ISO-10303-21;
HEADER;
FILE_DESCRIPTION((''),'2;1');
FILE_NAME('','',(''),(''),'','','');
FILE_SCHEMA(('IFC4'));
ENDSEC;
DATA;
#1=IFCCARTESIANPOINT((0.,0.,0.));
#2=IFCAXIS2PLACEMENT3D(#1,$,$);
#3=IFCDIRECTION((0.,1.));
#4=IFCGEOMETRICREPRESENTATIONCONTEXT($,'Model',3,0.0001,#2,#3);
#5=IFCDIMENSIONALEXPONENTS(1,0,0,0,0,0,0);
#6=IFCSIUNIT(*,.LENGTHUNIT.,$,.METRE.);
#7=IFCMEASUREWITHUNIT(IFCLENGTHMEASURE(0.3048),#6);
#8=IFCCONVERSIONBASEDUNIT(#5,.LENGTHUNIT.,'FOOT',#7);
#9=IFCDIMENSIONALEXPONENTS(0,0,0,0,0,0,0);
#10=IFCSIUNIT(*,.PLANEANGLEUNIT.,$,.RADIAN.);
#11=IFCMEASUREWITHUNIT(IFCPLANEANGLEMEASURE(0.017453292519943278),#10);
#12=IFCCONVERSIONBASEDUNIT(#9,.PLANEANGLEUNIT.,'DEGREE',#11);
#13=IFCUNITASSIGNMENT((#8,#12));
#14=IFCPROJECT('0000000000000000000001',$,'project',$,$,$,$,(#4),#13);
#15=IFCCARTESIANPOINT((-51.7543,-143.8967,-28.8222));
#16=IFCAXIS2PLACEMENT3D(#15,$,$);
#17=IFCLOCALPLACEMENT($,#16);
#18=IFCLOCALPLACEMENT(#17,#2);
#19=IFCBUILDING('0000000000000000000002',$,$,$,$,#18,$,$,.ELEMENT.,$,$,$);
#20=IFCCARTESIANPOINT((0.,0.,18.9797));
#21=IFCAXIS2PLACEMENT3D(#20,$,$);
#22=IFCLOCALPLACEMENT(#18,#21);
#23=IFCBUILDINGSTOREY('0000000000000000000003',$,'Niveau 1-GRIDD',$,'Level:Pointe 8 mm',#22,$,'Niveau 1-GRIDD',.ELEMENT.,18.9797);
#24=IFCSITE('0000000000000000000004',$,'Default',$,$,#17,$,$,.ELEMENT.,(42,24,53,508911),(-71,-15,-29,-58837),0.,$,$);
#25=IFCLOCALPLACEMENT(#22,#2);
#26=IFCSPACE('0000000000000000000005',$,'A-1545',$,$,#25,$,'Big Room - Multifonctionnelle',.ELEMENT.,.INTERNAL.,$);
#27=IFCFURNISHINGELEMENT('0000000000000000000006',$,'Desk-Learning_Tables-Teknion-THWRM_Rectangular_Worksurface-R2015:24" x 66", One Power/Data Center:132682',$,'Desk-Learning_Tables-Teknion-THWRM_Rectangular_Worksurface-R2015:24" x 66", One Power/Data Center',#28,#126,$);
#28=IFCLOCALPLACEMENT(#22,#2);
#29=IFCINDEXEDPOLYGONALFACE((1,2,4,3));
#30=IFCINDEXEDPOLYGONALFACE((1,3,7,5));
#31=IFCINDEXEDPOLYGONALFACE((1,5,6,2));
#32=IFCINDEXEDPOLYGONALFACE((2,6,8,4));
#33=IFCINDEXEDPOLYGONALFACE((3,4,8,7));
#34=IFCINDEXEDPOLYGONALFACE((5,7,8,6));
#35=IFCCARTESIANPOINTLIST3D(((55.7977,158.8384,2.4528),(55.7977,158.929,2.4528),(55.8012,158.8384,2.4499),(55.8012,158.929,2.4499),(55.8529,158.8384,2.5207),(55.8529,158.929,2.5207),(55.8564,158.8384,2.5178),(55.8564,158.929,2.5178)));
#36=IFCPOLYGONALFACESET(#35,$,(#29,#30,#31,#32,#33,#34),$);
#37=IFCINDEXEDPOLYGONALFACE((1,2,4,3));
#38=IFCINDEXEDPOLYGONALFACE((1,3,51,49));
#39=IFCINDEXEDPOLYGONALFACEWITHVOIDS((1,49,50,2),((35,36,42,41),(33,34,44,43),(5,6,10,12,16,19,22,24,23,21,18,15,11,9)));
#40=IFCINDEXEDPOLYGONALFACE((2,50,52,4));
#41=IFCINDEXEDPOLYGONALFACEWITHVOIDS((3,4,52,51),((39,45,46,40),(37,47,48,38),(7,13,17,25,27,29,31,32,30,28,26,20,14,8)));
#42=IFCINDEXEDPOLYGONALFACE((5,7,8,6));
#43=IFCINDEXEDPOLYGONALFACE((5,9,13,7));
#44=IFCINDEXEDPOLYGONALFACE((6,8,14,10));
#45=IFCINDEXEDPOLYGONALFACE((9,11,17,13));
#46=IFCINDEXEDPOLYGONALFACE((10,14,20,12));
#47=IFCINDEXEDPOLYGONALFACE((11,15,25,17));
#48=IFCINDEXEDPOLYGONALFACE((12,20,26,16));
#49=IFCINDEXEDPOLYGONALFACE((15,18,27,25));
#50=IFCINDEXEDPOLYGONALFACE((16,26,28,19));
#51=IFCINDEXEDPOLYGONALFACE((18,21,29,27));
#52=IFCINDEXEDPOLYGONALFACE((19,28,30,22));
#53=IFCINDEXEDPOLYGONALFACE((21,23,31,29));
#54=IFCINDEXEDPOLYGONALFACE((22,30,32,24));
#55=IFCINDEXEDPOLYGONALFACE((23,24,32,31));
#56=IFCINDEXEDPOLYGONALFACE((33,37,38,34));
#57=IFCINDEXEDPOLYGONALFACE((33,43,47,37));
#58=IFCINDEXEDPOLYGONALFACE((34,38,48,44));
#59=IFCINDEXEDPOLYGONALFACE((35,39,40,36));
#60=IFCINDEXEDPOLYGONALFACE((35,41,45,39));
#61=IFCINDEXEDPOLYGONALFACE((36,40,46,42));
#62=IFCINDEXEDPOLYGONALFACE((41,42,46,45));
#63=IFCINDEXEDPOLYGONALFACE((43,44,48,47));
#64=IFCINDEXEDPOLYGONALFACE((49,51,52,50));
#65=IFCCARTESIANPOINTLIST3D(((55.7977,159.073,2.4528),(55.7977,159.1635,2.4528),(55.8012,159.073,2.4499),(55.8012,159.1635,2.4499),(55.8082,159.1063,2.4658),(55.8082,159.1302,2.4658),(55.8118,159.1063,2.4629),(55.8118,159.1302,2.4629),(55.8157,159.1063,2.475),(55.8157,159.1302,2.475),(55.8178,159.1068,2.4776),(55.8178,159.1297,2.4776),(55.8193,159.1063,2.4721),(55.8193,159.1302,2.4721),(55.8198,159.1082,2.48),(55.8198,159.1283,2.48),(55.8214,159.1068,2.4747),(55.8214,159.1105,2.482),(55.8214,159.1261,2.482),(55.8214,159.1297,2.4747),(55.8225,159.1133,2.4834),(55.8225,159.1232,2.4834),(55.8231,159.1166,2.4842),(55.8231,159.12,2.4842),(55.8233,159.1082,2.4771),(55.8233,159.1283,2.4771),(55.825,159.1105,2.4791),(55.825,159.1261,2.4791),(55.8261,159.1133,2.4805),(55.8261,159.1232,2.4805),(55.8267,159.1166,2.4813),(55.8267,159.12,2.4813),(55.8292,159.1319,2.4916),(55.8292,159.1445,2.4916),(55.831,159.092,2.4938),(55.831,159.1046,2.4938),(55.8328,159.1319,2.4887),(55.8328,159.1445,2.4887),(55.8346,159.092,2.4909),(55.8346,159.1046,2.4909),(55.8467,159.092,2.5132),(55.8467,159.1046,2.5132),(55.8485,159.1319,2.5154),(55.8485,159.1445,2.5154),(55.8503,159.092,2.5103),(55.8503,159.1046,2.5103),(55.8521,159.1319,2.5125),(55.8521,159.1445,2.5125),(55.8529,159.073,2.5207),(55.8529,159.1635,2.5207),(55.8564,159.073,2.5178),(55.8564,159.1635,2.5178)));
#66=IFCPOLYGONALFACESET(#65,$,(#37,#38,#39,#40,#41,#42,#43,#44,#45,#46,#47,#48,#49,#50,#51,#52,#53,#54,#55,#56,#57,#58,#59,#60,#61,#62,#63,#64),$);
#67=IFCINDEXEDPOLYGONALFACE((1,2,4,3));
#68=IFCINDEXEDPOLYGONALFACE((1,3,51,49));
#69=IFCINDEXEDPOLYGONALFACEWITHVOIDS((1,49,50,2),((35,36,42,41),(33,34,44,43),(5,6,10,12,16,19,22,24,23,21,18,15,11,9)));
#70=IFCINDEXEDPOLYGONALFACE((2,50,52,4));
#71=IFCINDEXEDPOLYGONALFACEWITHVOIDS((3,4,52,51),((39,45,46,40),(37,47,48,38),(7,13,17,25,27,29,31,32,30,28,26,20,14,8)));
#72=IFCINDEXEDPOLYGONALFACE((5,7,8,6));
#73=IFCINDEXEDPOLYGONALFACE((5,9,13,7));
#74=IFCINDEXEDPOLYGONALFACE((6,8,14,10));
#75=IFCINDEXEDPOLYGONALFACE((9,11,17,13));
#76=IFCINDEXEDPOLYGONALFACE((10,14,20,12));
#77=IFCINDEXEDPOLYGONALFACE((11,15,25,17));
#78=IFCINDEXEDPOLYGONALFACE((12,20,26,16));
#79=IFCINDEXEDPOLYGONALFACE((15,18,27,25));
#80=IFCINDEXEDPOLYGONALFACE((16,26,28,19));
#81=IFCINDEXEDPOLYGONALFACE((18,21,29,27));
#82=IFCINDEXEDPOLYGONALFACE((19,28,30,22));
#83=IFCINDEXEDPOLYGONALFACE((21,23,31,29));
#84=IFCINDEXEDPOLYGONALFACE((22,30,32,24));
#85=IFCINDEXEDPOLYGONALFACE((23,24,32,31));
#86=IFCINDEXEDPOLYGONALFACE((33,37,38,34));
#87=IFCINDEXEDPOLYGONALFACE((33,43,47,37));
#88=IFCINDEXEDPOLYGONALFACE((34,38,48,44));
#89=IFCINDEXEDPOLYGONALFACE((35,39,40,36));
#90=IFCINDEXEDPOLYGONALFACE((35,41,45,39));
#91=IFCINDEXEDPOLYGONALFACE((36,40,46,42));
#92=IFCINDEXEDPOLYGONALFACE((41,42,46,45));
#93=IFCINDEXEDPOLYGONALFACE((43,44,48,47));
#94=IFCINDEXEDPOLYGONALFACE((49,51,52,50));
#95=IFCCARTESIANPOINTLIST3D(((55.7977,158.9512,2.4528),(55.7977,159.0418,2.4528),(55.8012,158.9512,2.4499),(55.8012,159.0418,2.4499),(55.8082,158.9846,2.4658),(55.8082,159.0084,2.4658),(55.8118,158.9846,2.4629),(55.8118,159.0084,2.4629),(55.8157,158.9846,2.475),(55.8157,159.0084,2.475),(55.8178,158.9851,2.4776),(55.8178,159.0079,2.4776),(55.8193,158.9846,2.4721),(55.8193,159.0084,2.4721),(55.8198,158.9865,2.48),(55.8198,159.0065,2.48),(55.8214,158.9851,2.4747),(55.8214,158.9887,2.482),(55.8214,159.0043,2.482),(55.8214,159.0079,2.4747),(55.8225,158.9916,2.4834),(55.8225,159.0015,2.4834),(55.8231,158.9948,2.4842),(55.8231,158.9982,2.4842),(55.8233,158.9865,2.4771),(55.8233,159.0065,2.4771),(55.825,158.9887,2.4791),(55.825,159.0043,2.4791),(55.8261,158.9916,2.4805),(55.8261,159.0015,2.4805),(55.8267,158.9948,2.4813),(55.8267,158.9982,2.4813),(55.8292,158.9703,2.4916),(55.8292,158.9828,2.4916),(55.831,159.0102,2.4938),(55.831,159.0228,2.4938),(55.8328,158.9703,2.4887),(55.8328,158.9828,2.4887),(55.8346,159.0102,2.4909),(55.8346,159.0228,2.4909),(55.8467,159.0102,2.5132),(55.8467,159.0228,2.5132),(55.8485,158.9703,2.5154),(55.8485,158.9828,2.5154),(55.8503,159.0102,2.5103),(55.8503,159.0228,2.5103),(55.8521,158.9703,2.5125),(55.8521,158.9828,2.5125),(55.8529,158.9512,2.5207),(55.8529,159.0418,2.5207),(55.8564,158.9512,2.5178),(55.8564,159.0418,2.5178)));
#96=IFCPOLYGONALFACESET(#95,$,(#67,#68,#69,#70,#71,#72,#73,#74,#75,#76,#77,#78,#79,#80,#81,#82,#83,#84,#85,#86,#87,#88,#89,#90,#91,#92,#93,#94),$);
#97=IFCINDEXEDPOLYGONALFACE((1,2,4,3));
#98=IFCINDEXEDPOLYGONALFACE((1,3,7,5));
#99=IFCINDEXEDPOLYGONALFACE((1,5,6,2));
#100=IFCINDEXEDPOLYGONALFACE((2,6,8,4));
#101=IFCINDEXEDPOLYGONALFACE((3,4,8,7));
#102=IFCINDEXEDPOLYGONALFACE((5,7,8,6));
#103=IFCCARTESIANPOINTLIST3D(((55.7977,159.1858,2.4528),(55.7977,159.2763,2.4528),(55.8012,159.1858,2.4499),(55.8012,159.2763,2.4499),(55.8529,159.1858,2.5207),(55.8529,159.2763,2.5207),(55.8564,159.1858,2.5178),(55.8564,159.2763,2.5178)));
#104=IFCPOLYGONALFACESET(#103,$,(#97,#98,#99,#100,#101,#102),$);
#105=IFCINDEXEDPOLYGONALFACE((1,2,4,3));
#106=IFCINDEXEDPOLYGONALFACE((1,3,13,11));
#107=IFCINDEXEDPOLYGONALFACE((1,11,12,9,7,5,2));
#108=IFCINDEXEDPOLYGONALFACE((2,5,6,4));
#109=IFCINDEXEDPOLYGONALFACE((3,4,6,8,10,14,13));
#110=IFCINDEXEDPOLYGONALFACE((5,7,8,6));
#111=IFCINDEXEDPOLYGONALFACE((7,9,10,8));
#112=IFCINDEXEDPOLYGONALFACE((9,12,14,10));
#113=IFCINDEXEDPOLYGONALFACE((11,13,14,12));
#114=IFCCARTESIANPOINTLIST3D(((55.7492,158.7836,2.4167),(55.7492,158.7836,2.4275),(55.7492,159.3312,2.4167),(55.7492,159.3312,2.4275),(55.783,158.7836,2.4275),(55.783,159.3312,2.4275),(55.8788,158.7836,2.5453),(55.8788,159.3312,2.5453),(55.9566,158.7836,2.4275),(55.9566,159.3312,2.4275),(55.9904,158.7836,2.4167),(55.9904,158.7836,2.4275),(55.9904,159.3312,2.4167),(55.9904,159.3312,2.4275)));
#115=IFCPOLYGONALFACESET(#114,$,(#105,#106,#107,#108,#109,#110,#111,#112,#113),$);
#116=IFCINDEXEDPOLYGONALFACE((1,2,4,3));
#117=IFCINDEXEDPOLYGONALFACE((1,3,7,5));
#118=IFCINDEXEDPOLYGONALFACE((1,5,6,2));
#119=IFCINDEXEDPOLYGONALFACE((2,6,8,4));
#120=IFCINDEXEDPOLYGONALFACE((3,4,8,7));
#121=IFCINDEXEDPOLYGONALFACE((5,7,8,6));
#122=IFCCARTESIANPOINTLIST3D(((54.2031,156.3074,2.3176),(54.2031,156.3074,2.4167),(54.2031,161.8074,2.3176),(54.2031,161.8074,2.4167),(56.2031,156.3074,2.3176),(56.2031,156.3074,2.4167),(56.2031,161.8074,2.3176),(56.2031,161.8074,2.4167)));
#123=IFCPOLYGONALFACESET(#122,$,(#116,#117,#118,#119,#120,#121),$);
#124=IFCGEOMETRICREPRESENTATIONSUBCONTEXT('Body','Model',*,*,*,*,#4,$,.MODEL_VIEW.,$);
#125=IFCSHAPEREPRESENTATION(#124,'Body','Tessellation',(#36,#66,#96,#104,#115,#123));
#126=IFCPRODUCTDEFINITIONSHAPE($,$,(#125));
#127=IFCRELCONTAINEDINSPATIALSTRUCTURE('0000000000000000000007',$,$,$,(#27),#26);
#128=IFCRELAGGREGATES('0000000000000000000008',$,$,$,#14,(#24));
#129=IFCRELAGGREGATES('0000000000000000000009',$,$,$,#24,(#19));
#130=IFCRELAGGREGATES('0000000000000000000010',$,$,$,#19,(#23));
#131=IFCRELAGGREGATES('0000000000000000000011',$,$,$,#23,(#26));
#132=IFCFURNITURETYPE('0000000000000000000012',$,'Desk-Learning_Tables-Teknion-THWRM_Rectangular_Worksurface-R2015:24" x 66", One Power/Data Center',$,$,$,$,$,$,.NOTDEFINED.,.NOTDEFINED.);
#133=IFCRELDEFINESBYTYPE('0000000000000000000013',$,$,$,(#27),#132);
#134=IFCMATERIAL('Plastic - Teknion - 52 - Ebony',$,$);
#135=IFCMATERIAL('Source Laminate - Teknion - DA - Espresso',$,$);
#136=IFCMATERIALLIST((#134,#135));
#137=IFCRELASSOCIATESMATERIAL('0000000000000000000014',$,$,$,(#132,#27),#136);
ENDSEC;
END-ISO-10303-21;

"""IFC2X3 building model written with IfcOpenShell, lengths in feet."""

from ifc_helpers import new_model, entity, si_unit, converted_unit, direction, frame, frame_2d, origin, place, context, subcontext, project, spatial, polyline, circle_curve, parameter, trimmed, segment, composite_curve, rectangle, outline, extrude, source, transform, mapped, material, material_list, type_object, type_shapes, element, save


model = new_model("IFC2X3")

# Units and contexts
model_context = context("Model", 3, precision=0.0001, world=origin(), true_north=direction((0.0, 1.0)))
body_context = subcontext(model_context, "Body", "Model", "MODEL_VIEW")
ifc_project = project(units=[converted_unit("LENGTHUNIT", "FOOT", entity("IfcLengthMeasure", 0.3048), si_unit("LENGTHUNIT", "METRE"), dimensions=[1, 0, 0, 0, 0, 0, 0]), converted_unit("PLANEANGLEUNIT", "DEGREE", entity("IfcPlaneAngleMeasure", 0.017453292519943278), si_unit("PLANEANGLEUNIT", "RADIAN"), dimensions=[0, 0, 0, 0, 0, 0, 0])], contexts=[model_context])

# Site, building, storey
site_placement = place(None, frame((-51.7543, -143.8967, -28.8222)))
site = spatial("IfcSite", under=ifc_project, at=site_placement, Name="Default", CompositionType="ELEMENT", RefLatitude=(42, 24, 53, 508911), RefLongitude=(-71, -15, -29, -58837), RefElevation=0.0)
building_placement = place(site_placement, origin())
building = spatial("IfcBuilding", under=site, at=building_placement, CompositionType="ELEMENT")
storey_placement = place(building_placement, frame((0.0, 0.0, 18.9797)))
storey = spatial("IfcBuildingStorey", under=building, at=storey_placement, Name="Niveau 1-GRIDD", ObjectType="Level:Pointe 8 mm", LongName="Niveau 1-GRIDD", CompositionType="ELEMENT", Elevation=18.9797)

# Shared definitions
space_placement = place(storey_placement, origin())
space = spatial("IfcSpace", under=storey, at=space_placement, Name="A-1545", LongName="Big Room - Multifonctionnelle", CompositionType="ELEMENT", InteriorOrExteriorSpace="INTERNAL")

# Furnishing element
ifc_material_1 = material(Name="Plastic - Teknion - 52 - Ebony")
ifc_material_2 = material(Name="Source Laminate - Teknion - DA - Espresso")
ifc_material_list_1 = material_list([ifc_material_1, ifc_material_2])
furniture_type_1 = type_object("IfcFurnitureType", Name="Desk-Learning_Tables-Teknion-THWRM_Rectangular_Worksurface-R2015:24\" x 66\", One Power/Data Center", AssemblyPlace="NOTDEFINED", material=ifc_material_list_1)
shared_shape_1 = source(origin(), body_context, "Body", "SweptSolid", [
    extrude(rectangle(XDim=0.0875, YDim=0.0046, at=frame_2d((0.0, 0.0), x_axis=(0.0, 1.0))), frame((0.1284, 0.6239, 2.4853), z_axis=(1.0, 0.0, 0.0), x_axis=(0.0, 0.776046, -0.630676)), (0.0, 0.0, 1.0), 0.0906),
    extrude(outline(polyline([(-0.0453, -0.0438), (0.0453, -0.0438), (0.0453, 0.0438), (-0.0453, 0.0438), (-0.0453, -0.0438)]), holes=[polyline([(-0.0262, -0.0063), (-0.0137, -0.0063), (-0.0137, -0.0369), (-0.0262, -0.0369), (-0.0262, -0.0063)]), polyline([(0.0137, -0.0341), (0.0137, -0.0091), (0.0262, -0.0091), (0.0262, -0.0341), (0.0137, -0.0341)]), composite_curve([segment(polyline([(-0.0119, 0.027), (0.0119, 0.027)]), True, "CONTINUOUS"), segment(polyline([(0.0119, 0.027), (0.0119, 0.0151)]), True, "CONTINUOUS"), segment(trimmed(circle_curve(frame_2d((0.0, 0.0151), x_axis=(0.0, -1.0)), 0.0119), [parameter(270.0)], [parameter(90.0)], True, "PARAMETER"), False, "CONTINUOUS"), segment(polyline([(-0.0119, 0.0151), (-0.0119, 0.027)]), True, "CONTINUOUS")], self_intersect=False)]), frame((-0.0609, 0.6221, 2.4867), z_axis=(0.0, 0.776046, -0.630676), x_axis=(1.0, 0.0, 0.0)), (0.0, 0.0, 1.0), 0.0046),
    extrude(outline(polyline([(-0.0438, -0.0453), (0.0438, -0.0453), (0.0438, 0.0453), (-0.0438, 0.0453), (-0.0438, -0.0453)]), holes=[polyline([(-0.0063, -0.0262), (-0.0369, -0.0262), (-0.0369, -0.0137), (-0.0063, -0.0137), (-0.0063, -0.0262)]), polyline([(-0.0341, 0.0137), (-0.0341, 0.0262), (-0.0091, 0.0262), (-0.0091, 0.0137), (-0.0341, 0.0137)]), composite_curve([segment(polyline([(0.027, -0.0119), (0.0151, -0.0119)]), True, "CONTINUOUS"), segment(trimmed(circle_curve(frame_2d((0.0151, 0.0), x_axis=(-1.0, 0.0)), 0.0119), [parameter(270.0)], [parameter(90.0)], True, "PARAMETER"), False, "CONTINUOUS"), segment(polyline([(0.0151, 0.0119), (0.027, 0.0119)]), True, "CONTINUOUS"), segment(polyline([(0.027, 0.0119), (0.027, -0.0119)]), True, "CONTINUOUS")], self_intersect=False)]), frame((0.0609, 0.6221, 2.4867), z_axis=(0.0, 0.776046, -0.630676), x_axis=(0.0, -0.630676, -0.776046)), (0.0, 0.0, 1.0), 0.0046),
    extrude(rectangle(XDim=0.0875, YDim=0.0046, at=frame_2d((0.0, 0.0), x_axis=(0.0, 1.0))), frame((-0.219, 0.6239, 2.4853), z_axis=(1.0, 0.0, 0.0), x_axis=(0.0, 0.776046, -0.630676)), (0.0, 0.0, 1.0), 0.0906),
    extrude(outline(polyline([(-0.0586, -0.0638), (0.0826, -0.0638), (0.0371, 0.0811), (0.0557, 0.1093), (0.0467, 0.1152), (-0.0862, -0.086), (-0.0772, -0.092), (-0.0586, -0.0638)])), frame((-0.2738, 0.6679, 2.4412), z_axis=(1.0, 0.0, 0.0), x_axis=(0.0, -0.551103, 0.834437)), (0.0, 0.0, 1.0), 0.5475),
    extrude(rectangle(XDim=5.5, YDim=2.0, at=frame_2d((0.0, 0.0), x_axis=(1.0, 0.0))), frame((0.0, 0.0, 2.3176), z_axis=(0.0, 0.0, 1.0), x_axis=(-1.0, 0.0, 0.0)), (0.0, 0.0, 1.0), 0.0991),
])
type_shapes(furniture_type_1, [shared_shape_1])
for number, where, z_axis, x_axis, name in (
    (1, (55.2031, 159.0574, 0.0), (0.0, 0.0, 1.0), (0.0, -1.0, 0.0), "Desk-Learning_Tables-Teknion-THWRM_Rectangular_Worksurface-R2015:24\" x 66\", One Power/Data Center:132682"),
):
    element("IfcFurnishingElement", number, at=place(space_placement, frame(where, z_axis=z_axis, x_axis=x_axis)), inside=space, type_object=furniture_type_1, material=ifc_material_list_1, Name=name, ObjectType="Desk-Learning_Tables-Teknion-THWRM_Rectangular_Worksurface-R2015:24\" x 66\", One Power/Data Center", context=body_context, shape_type="MappedRepresentation", body=[
        mapped(shared_shape_1, transform((0.0, 0.0, 0.0), scale=1.0)),
    ])

save(model, "model.ifc")
